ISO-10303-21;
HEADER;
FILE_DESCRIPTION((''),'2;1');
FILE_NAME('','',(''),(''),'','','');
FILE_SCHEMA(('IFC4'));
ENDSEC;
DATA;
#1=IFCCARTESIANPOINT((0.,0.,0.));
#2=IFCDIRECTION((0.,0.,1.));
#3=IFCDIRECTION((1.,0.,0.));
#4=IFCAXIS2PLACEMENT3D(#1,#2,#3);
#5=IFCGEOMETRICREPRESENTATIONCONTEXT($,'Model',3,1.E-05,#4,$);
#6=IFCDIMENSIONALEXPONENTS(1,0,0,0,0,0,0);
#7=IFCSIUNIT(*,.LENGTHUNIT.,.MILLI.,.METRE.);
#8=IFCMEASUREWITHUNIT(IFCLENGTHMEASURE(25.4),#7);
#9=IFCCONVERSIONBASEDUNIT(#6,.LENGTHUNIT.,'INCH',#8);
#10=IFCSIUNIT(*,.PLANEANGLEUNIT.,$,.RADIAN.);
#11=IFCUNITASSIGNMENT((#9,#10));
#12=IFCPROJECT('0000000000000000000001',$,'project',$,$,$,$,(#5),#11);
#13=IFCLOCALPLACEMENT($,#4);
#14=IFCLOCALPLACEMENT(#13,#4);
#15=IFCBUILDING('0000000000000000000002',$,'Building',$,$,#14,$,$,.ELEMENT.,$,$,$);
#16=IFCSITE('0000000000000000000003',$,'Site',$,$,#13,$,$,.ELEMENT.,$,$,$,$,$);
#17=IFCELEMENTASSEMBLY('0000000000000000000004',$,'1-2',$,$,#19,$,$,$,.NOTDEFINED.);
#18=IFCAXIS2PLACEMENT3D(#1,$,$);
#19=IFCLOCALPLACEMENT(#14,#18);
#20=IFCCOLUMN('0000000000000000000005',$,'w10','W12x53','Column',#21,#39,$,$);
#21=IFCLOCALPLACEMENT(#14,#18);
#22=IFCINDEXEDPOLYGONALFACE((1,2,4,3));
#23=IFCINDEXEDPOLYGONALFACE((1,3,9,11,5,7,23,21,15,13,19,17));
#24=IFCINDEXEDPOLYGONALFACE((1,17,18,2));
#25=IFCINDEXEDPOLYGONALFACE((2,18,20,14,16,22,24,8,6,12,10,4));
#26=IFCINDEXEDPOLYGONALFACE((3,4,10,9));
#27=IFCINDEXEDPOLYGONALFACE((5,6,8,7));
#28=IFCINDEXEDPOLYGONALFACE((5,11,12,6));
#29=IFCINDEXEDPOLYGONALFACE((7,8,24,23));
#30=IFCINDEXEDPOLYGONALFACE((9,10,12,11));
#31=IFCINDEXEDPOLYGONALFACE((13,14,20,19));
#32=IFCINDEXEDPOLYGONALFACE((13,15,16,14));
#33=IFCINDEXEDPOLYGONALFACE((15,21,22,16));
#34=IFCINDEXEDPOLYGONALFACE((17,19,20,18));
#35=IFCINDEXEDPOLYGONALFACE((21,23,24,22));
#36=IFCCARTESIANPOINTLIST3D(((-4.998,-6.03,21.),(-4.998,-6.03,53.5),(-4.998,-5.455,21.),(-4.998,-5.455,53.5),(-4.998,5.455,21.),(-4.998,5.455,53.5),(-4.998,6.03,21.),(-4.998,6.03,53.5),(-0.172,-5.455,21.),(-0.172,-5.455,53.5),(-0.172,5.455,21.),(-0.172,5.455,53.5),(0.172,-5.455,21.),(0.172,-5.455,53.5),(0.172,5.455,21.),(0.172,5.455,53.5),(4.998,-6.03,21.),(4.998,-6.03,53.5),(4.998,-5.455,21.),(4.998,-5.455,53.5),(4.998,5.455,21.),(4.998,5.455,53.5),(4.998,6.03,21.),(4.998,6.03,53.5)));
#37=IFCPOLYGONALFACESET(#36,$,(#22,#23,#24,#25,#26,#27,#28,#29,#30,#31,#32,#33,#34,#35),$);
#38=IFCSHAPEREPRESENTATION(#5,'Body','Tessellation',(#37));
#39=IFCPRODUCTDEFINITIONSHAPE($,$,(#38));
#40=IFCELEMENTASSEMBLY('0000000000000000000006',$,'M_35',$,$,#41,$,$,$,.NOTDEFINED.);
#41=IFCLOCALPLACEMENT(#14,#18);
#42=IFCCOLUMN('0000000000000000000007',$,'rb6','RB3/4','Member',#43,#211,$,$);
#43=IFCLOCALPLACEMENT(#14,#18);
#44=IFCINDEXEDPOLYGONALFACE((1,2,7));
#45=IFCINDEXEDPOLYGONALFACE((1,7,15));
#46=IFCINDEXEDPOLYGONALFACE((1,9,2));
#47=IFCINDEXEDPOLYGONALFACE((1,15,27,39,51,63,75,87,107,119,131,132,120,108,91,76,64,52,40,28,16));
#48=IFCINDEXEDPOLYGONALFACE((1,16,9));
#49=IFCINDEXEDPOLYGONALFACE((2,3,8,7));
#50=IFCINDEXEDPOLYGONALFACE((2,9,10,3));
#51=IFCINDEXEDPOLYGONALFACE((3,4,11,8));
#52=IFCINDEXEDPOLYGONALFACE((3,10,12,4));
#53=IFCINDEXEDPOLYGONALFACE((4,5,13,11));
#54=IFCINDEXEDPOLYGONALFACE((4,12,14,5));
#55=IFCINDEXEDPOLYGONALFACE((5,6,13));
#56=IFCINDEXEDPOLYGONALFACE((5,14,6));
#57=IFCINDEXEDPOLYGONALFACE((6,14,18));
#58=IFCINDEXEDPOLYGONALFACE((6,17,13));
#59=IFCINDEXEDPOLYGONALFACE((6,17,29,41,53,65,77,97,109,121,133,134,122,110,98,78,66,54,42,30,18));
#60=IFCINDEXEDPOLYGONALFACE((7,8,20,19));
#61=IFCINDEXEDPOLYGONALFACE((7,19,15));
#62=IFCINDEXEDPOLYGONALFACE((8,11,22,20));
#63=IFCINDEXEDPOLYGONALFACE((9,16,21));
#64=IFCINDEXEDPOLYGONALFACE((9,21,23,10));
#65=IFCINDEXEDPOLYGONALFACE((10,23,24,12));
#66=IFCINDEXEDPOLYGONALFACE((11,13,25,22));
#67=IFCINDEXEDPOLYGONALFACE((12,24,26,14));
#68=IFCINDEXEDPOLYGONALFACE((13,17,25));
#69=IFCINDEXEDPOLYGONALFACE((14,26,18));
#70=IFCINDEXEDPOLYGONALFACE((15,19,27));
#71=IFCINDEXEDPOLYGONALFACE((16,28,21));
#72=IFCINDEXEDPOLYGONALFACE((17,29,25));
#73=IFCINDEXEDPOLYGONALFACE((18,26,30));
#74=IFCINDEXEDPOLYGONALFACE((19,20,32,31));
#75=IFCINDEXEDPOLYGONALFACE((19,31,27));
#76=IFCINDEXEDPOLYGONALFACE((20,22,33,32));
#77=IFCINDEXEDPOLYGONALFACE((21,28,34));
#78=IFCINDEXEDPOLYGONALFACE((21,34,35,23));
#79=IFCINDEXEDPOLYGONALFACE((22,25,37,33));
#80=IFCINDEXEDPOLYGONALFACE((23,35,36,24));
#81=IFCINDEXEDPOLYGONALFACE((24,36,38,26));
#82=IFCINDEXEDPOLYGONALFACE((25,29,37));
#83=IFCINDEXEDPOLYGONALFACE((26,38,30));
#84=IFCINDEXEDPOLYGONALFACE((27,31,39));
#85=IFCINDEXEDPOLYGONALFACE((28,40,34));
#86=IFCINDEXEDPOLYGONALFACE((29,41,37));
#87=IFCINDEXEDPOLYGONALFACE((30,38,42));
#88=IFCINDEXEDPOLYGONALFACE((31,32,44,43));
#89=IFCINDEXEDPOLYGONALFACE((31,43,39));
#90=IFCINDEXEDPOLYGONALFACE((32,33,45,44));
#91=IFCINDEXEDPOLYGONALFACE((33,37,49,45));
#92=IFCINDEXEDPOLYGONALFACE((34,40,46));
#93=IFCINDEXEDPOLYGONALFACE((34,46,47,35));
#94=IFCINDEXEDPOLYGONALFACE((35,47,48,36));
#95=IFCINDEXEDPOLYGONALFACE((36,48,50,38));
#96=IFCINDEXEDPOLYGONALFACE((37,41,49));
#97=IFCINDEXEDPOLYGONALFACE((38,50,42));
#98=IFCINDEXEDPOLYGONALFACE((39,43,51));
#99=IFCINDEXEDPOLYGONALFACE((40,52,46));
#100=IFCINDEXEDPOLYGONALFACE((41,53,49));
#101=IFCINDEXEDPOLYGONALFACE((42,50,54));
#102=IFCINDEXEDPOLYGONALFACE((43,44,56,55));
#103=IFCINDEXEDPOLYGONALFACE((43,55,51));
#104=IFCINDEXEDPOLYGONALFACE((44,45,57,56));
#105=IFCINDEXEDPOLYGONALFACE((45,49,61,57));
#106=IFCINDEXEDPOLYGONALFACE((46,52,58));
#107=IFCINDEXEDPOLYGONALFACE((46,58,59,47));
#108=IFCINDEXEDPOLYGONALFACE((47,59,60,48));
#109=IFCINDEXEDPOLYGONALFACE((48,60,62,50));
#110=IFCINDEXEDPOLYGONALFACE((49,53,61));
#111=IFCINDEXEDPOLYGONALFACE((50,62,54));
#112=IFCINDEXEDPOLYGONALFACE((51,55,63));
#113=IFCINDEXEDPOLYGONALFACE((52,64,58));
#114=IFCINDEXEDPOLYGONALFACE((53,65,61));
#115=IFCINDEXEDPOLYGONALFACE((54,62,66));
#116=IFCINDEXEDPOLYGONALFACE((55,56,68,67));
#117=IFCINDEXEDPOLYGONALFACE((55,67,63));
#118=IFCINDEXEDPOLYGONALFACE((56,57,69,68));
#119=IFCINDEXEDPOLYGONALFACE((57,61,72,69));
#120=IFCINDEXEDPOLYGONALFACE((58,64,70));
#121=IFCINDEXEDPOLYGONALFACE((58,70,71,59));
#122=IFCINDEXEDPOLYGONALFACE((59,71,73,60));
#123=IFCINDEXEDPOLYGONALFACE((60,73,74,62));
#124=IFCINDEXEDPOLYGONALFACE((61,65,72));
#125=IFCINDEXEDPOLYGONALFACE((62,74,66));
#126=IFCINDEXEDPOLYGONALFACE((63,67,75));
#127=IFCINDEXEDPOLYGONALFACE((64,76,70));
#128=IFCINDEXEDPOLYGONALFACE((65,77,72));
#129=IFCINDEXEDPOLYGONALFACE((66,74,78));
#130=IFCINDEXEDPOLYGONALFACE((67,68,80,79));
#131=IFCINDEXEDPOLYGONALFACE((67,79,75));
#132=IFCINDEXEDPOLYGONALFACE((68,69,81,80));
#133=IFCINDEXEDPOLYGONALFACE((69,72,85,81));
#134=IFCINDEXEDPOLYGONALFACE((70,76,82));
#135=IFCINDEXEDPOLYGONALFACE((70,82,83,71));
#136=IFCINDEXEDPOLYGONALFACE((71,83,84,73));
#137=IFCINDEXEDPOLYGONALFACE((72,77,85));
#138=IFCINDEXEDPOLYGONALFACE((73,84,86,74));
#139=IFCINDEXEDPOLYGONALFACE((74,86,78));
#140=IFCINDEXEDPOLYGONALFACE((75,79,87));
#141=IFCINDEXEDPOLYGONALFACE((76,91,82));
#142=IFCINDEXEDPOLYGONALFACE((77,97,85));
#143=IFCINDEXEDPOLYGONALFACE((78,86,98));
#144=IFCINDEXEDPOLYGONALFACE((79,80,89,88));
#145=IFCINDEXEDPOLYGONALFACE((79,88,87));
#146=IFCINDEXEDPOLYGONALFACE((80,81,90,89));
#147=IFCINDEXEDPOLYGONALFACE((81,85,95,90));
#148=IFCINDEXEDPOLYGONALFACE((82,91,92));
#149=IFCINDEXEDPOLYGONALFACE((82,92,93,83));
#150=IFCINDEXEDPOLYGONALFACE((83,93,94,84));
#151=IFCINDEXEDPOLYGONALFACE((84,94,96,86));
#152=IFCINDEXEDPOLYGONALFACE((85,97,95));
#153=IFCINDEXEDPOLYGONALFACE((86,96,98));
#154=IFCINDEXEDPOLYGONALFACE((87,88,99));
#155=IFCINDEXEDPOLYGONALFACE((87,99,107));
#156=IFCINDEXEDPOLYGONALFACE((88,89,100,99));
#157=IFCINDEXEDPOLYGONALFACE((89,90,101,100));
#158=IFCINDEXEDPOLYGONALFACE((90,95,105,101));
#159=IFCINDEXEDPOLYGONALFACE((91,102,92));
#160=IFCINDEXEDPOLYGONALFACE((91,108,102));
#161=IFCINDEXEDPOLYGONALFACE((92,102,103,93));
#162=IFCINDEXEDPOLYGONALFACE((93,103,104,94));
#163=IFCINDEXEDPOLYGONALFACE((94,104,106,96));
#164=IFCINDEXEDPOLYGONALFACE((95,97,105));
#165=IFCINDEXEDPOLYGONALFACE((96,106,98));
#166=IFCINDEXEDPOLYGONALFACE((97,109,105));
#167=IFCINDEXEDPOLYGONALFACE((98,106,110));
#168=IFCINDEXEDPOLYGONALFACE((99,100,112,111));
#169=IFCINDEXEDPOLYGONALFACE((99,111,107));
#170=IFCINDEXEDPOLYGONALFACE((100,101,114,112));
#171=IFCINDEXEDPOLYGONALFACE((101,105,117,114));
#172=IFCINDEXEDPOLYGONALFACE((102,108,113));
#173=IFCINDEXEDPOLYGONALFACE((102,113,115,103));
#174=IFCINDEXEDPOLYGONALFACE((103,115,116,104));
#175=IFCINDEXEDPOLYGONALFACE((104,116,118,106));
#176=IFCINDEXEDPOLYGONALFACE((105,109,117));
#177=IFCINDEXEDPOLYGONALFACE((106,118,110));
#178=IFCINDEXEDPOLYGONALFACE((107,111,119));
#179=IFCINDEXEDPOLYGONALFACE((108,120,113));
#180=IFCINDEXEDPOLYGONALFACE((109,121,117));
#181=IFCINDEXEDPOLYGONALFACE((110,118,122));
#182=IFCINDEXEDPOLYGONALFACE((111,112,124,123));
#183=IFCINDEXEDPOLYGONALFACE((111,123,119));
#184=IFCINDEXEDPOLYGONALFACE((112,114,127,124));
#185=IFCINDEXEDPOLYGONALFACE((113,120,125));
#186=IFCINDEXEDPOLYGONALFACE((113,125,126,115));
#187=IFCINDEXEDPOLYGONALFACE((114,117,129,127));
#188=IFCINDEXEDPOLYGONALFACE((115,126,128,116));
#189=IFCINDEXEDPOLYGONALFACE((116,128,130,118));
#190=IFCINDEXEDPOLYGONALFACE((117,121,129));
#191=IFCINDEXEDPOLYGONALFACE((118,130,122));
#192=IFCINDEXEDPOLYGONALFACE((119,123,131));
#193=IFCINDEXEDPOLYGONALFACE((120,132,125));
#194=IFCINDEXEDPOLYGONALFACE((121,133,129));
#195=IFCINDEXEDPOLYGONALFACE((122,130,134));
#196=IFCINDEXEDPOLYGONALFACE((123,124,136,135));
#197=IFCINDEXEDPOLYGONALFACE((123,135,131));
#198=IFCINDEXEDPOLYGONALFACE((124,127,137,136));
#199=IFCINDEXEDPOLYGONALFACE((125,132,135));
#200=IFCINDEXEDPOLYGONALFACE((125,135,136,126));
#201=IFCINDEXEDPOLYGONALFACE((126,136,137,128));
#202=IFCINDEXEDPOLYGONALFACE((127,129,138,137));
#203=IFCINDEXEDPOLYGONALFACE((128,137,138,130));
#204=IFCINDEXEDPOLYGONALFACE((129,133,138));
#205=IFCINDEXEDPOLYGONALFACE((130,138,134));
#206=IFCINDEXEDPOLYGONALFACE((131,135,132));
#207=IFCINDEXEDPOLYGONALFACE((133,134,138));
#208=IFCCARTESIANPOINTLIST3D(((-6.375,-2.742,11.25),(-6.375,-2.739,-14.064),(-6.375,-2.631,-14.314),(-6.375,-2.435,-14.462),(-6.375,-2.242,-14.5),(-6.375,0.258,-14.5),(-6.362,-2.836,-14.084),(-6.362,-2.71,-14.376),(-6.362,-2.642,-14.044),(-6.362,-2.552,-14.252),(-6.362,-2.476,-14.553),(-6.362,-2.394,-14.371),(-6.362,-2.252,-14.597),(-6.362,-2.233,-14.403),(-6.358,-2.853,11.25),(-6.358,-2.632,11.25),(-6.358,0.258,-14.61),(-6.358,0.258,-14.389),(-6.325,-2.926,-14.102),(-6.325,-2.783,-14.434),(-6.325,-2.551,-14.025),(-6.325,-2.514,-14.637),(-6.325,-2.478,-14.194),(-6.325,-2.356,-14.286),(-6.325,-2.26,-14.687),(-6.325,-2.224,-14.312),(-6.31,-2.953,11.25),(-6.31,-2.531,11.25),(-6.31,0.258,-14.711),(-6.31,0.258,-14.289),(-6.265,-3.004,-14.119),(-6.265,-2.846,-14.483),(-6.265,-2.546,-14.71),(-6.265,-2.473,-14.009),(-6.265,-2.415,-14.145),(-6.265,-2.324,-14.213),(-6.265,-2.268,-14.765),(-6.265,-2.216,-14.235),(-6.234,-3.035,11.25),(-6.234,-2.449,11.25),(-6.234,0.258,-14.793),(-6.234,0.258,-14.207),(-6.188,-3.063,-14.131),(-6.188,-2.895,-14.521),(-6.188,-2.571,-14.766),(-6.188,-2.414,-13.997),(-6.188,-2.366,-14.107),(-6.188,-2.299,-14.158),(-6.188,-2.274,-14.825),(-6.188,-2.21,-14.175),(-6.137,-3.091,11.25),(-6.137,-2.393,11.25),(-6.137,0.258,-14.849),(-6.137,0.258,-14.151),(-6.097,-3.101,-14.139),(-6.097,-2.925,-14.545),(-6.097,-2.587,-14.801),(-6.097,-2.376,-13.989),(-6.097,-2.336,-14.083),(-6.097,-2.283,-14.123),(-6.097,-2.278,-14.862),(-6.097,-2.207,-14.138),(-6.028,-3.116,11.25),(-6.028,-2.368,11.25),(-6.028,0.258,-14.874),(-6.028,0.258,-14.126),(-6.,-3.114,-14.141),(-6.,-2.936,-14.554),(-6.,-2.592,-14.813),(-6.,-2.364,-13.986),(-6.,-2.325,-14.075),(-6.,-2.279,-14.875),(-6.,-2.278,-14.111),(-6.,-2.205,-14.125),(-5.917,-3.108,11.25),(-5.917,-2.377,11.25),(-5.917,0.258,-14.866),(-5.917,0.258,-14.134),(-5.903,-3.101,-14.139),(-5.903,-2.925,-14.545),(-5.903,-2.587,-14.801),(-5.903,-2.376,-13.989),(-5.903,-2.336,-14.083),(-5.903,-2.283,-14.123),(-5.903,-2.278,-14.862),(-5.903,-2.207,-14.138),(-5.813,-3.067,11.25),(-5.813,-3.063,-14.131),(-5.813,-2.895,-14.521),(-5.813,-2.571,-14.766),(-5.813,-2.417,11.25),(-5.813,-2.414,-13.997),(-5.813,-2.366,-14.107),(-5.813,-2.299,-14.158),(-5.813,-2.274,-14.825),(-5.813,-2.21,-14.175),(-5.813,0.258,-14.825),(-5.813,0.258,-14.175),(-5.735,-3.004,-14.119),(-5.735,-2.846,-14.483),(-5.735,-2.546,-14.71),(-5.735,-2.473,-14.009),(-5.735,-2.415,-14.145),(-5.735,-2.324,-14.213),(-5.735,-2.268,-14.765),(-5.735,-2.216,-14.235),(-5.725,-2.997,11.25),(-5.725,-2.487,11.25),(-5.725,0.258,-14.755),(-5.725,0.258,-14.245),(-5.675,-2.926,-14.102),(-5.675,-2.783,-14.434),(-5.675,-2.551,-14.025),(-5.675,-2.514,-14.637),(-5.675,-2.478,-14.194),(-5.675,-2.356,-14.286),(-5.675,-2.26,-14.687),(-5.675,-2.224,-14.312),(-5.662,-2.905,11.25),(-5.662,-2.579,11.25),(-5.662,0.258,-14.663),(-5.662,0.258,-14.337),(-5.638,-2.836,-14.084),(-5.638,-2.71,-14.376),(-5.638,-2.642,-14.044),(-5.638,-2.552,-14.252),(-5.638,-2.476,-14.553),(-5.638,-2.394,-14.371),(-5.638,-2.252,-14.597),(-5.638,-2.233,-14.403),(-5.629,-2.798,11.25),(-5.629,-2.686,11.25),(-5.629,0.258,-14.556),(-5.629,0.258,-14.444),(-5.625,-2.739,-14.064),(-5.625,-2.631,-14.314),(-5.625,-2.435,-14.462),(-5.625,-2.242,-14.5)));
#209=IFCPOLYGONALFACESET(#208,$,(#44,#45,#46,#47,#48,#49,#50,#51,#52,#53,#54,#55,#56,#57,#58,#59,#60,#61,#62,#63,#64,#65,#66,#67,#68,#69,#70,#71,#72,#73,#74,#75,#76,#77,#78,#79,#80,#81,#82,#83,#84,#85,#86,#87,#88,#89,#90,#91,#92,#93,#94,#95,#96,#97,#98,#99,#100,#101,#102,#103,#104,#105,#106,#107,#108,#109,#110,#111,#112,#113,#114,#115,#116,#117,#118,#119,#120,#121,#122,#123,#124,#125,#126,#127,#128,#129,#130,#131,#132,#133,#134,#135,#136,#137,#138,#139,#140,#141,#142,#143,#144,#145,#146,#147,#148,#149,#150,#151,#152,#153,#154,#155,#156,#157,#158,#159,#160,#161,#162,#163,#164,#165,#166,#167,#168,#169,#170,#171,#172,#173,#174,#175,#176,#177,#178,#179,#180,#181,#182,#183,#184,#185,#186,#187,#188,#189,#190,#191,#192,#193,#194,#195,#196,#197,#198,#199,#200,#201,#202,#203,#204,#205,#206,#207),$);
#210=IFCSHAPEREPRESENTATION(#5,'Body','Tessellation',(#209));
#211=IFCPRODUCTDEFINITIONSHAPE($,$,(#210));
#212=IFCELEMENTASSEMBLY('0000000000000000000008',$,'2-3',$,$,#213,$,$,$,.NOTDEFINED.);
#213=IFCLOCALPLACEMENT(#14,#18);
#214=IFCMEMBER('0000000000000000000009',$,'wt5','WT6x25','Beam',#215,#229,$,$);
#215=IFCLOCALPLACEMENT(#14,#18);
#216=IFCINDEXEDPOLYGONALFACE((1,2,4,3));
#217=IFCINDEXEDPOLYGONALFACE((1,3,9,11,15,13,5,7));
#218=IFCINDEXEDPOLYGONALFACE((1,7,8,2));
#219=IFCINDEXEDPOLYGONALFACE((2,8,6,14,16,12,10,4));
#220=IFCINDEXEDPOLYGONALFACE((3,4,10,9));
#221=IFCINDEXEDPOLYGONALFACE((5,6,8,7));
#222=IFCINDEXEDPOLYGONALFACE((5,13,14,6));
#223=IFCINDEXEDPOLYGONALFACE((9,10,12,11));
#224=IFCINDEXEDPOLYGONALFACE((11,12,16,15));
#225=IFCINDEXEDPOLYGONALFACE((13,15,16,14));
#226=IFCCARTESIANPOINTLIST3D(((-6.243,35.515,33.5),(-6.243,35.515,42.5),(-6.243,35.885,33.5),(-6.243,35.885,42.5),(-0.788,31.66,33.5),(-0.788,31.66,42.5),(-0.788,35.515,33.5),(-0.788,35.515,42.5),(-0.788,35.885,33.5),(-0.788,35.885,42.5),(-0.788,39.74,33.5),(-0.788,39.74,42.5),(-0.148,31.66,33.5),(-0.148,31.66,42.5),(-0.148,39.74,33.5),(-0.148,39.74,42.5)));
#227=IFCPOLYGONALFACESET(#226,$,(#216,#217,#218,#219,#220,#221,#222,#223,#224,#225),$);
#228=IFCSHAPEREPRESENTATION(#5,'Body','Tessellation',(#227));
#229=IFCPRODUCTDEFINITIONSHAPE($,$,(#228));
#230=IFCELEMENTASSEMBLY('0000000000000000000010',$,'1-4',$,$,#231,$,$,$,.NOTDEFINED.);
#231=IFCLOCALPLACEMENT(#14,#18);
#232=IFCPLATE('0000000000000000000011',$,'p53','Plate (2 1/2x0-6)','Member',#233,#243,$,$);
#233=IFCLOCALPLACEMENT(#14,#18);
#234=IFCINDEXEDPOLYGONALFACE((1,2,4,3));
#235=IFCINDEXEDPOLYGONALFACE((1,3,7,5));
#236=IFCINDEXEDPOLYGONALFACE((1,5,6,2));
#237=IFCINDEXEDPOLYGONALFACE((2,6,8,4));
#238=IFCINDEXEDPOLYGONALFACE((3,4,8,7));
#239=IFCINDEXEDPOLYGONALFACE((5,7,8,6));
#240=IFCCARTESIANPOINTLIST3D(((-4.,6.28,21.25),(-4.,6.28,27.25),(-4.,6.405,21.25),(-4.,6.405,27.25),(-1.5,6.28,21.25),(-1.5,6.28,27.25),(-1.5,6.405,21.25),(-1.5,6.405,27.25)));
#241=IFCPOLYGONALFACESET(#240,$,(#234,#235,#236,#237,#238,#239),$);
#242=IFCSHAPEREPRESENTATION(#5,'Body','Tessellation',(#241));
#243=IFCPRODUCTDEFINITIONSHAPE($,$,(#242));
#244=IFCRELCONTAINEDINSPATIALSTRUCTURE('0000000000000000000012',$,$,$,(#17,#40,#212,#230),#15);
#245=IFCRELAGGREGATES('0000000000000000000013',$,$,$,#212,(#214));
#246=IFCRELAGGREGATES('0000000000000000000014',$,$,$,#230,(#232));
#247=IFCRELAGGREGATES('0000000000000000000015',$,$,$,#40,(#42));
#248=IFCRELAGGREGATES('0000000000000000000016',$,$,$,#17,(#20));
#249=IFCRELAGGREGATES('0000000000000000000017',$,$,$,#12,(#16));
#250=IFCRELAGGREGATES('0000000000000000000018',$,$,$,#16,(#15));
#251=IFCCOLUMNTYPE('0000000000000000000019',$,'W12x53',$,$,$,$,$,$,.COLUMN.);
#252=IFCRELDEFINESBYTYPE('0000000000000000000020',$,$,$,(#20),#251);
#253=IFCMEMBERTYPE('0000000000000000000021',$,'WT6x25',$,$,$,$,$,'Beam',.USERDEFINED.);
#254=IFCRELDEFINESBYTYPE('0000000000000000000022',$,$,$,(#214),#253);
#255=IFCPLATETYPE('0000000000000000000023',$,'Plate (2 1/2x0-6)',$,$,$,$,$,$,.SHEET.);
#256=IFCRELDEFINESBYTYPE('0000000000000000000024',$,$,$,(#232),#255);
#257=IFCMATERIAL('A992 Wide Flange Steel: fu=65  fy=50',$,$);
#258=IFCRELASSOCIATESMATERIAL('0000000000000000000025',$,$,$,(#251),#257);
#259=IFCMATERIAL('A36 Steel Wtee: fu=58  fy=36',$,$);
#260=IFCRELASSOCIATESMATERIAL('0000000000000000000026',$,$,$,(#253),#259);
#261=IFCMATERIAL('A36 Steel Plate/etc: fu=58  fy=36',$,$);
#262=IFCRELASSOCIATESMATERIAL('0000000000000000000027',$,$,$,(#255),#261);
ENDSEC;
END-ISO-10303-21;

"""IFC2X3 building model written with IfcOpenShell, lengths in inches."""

from ifc_helpers import new_model, entity, si_unit, converted_unit, frame, frame_2d, origin_with_axes, origin_2d_with_axis, place, context, project, spatial, polyline, i_section, t_section, outline, extrude, source, transform, mapped, material, type_object, type_shapes, element, aggregate, save


model = new_model("IFC2X3")

# Units and contexts
model_context = context("Model", 3, precision=1e-05, world=origin_with_axes())
ifc_project = project(units=[converted_unit("LENGTHUNIT", "INCH", entity("IfcLengthMeasure", 25.4), si_unit("LENGTHUNIT", "METRE", prefix="MILLI"), dimensions=[1, 0, 0, 0, 0, 0, 0]), si_unit("PLANEANGLEUNIT", "RADIAN")], contexts=[model_context])

# Site, building
site_placement = place(None, origin_with_axes())
site = spatial("IfcSite", under=ifc_project, at=site_placement, Name="Site", CompositionType="ELEMENT")
building_placement = place(site_placement, origin_with_axes())
building = spatial("IfcBuilding", under=site, at=building_placement, Name="Building", CompositionType="ELEMENT")

# Element assemblies, columns
ifc_material_1 = material(Name="A992 Wide Flange Steel: fu=65  fy=50")
assembly_1_placement = place(building_placement, frame((0.0, 0.0, 21.0), z_axis=(0.0, -1.0, 0.0), x_axis=(0.0, 0.0, 1.0)))
assembly_1 = element("IfcElementAssembly", 1, at=assembly_1_placement, inside=building, Name="1-2", PredefinedType="NOTDEFINED")
column_type_1 = type_object("IfcColumnType", Name="W12x53", PredefinedType="COLUMN", material=ifc_material_1)
shared_shape_1 = source(origin_with_axes(), model_context, "Body", "SweptSolid", [
    extrude(i_section(OverallWidth=9.995, OverallDepth=12.06, WebThickness=0.345, FlangeThickness=0.575, at=origin_2d_with_axis()), frame((0.0, 0.0, 0.0), z_axis=(1.0, 0.0, 0.0), x_axis=(0.0, 1.0, 0.0)), (0.0, 0.0, 1.0), 32.5),
])
type_shapes(column_type_1, [shared_shape_1])
column_1_placement = place(assembly_1_placement, origin_with_axes())
column_1 = element("IfcColumn", 2, at=column_1_placement, type_object=column_type_1, Name="w10", Description="W12x53", ObjectType="Column", context=model_context, shape_type="MappedRepresentation", body=[
    mapped(shared_shape_1, transform((0.0, 0.0, 0.0), scale=1.0)),
])
assembly_2_placement = place(building_placement, frame((-3.0, 0.0, -22.668), z_axis=(0.0, -1.0, 0.0), x_axis=(0.0, 0.0, 1.0)))
assembly_2 = element("IfcElementAssembly", 3, at=assembly_2_placement, inside=building, Name="M_35", PredefinedType="NOTDEFINED")
column_2_placement = place(assembly_2_placement, frame((8.44, 3.0, -0.258), z_axis=(0.0, 1.0, 0.0), x_axis=(-1.0, 0.0, 0.0)))
cartesian_point_1 = entity("IfcCartesianPoint", [0.0, 0.0, 0.0])
ifc_direction_1 = entity("IfcDirection", [0.0, 0.0, 1.0])
ifc_direction_2 = entity("IfcDirection", [1.0, 0.0, 0.0])
column_2 = element("IfcColumn", 4, at=column_2_placement, Name="rb6", Description="RB3/4", ObjectType="Member", context=model_context, shape_type="SweptSolid", body=[
    entity("IfcSurfaceCurveSweptAreaSolid", entity("IfcCircleProfileDef", "AREA", None, entity("IfcAxis2Placement2D", entity("IfcCartesianPoint", [0.0, 0.0]), entity("IfcDirection", [1.0, 0.0])), 0.375), entity("IfcAxis2Placement3D", cartesian_point_1, ifc_direction_1, ifc_direction_2), entity("IfcPolyline", [entity("IfcCartesianPoint", [0.272, 0.0]), entity("IfcCartesianPoint", [0.272, 2.5]), entity("IfcCartesianPoint", [0.234, 2.693]), entity("IfcCartesianPoint", [0.086, 2.888]), entity("IfcCartesianPoint", [-0.164, 2.996]), entity("IfcCartesianPoint", [-25.478, 3.0])]), 0.0, 1.0, entity("IfcPlane", entity("IfcAxis2Placement3D", cartesian_point_1, ifc_direction_1, ifc_direction_2))),
])

# Element assembly, member
assembly_3_placement = place(building_placement, frame((0.0, 0.0, 46.0), z_axis=(0.0, 0.0, 1.0), x_axis=(0.0, 1.0, 0.0)))
assembly_3 = element("IfcElementAssembly", 5, at=assembly_3_placement, inside=building, Name="2-3", PredefinedType="NOTDEFINED")
ifc_material_2 = material(Name="A36 Steel Wtee: fu=58  fy=36")
member_type = type_object("IfcMemberType", Name="WT6x25", ElementType="Beam", PredefinedType="USERDEFINED", material=ifc_material_2)
shared_shape_2 = source(origin_with_axes(), model_context, "Body", "SweptSolid", [
    extrude(t_section(Depth=6.095, FlangeWidth=8.08, WebThickness=0.37, FlangeThickness=0.64, at=frame_2d((0.0, -3.047), x_axis=(1.0, 0.0))), frame((0.0, 0.0, 0.0), z_axis=(1.0, 0.0, 0.0), x_axis=(0.0, 1.0, 0.0)), (0.0, 0.0, 1.0), 9.0),
])
type_shapes(member_type, [shared_shape_2])
member_placement = place(assembly_3_placement, frame((35.7, 0.148, -12.5), z_axis=(0.0, -1.0, 0.0), x_axis=(0.0, 0.0, 1.0)))
member = element("IfcMember", 6, at=member_placement, type_object=member_type, Name="wt5", Description="WT6x25", ObjectType="Beam", context=model_context, shape_type="MappedRepresentation", body=[
    mapped(shared_shape_2, transform((0.0, 0.0, 0.0), scale=1.0)),
])
aggregate(assembly_3, [member])

# Element assembly, plate
assembly_4_placement = place(building_placement, frame((-4.0, 6.28, 21.25), z_axis=(-1.0, 0.0, 0.0), x_axis=(0.0, -1.0, 0.0)))
assembly_4 = element("IfcElementAssembly", 7, at=assembly_4_placement, inside=building, Name="1-4", PredefinedType="NOTDEFINED")
ifc_material_3 = material(Name="A36 Steel Plate/etc: fu=58  fy=36")
plate_type_1 = type_object("IfcPlateType", Name="Plate (2 1/2x0-6)", PredefinedType="SHEET", material=ifc_material_3)
shared_shape_3 = source(origin_with_axes(), model_context, "Body", "SweptSolid", [
    extrude(outline(polyline([(0.0, -2.5), (-6.0, -2.5), (-6.0, 0.0), (0.0, 0.0), (0.0, -2.5)])), frame((-0.062, 0.0, 0.0), z_axis=(1.0, 0.0, 0.0), x_axis=(0.0, 1.0, 0.0)), (0.0, 0.0, 1.0), 0.125),
])
type_shapes(plate_type_1, [shared_shape_3])
plate_1_placement = place(assembly_4_placement, frame((-0.062, 0.0, 0.0), z_axis=(0.0, 0.0, 1.0), x_axis=(-1.0, 0.0, 0.0)))
plate_1 = element("IfcPlate", 8, at=plate_1_placement, type_object=plate_type_1, Name="p53", Description="Plate (2 1/2x0-6)", ObjectType="Member", context=model_context, shape_type="MappedRepresentation", body=[
    mapped(shared_shape_3, transform((0.0, 0.0, 0.0), scale=1.0)),
])
aggregate(assembly_4, [plate_1])

aggregate(assembly_2, [column_2])
aggregate(assembly_1, [column_1])

save(model, "model.ifc")
